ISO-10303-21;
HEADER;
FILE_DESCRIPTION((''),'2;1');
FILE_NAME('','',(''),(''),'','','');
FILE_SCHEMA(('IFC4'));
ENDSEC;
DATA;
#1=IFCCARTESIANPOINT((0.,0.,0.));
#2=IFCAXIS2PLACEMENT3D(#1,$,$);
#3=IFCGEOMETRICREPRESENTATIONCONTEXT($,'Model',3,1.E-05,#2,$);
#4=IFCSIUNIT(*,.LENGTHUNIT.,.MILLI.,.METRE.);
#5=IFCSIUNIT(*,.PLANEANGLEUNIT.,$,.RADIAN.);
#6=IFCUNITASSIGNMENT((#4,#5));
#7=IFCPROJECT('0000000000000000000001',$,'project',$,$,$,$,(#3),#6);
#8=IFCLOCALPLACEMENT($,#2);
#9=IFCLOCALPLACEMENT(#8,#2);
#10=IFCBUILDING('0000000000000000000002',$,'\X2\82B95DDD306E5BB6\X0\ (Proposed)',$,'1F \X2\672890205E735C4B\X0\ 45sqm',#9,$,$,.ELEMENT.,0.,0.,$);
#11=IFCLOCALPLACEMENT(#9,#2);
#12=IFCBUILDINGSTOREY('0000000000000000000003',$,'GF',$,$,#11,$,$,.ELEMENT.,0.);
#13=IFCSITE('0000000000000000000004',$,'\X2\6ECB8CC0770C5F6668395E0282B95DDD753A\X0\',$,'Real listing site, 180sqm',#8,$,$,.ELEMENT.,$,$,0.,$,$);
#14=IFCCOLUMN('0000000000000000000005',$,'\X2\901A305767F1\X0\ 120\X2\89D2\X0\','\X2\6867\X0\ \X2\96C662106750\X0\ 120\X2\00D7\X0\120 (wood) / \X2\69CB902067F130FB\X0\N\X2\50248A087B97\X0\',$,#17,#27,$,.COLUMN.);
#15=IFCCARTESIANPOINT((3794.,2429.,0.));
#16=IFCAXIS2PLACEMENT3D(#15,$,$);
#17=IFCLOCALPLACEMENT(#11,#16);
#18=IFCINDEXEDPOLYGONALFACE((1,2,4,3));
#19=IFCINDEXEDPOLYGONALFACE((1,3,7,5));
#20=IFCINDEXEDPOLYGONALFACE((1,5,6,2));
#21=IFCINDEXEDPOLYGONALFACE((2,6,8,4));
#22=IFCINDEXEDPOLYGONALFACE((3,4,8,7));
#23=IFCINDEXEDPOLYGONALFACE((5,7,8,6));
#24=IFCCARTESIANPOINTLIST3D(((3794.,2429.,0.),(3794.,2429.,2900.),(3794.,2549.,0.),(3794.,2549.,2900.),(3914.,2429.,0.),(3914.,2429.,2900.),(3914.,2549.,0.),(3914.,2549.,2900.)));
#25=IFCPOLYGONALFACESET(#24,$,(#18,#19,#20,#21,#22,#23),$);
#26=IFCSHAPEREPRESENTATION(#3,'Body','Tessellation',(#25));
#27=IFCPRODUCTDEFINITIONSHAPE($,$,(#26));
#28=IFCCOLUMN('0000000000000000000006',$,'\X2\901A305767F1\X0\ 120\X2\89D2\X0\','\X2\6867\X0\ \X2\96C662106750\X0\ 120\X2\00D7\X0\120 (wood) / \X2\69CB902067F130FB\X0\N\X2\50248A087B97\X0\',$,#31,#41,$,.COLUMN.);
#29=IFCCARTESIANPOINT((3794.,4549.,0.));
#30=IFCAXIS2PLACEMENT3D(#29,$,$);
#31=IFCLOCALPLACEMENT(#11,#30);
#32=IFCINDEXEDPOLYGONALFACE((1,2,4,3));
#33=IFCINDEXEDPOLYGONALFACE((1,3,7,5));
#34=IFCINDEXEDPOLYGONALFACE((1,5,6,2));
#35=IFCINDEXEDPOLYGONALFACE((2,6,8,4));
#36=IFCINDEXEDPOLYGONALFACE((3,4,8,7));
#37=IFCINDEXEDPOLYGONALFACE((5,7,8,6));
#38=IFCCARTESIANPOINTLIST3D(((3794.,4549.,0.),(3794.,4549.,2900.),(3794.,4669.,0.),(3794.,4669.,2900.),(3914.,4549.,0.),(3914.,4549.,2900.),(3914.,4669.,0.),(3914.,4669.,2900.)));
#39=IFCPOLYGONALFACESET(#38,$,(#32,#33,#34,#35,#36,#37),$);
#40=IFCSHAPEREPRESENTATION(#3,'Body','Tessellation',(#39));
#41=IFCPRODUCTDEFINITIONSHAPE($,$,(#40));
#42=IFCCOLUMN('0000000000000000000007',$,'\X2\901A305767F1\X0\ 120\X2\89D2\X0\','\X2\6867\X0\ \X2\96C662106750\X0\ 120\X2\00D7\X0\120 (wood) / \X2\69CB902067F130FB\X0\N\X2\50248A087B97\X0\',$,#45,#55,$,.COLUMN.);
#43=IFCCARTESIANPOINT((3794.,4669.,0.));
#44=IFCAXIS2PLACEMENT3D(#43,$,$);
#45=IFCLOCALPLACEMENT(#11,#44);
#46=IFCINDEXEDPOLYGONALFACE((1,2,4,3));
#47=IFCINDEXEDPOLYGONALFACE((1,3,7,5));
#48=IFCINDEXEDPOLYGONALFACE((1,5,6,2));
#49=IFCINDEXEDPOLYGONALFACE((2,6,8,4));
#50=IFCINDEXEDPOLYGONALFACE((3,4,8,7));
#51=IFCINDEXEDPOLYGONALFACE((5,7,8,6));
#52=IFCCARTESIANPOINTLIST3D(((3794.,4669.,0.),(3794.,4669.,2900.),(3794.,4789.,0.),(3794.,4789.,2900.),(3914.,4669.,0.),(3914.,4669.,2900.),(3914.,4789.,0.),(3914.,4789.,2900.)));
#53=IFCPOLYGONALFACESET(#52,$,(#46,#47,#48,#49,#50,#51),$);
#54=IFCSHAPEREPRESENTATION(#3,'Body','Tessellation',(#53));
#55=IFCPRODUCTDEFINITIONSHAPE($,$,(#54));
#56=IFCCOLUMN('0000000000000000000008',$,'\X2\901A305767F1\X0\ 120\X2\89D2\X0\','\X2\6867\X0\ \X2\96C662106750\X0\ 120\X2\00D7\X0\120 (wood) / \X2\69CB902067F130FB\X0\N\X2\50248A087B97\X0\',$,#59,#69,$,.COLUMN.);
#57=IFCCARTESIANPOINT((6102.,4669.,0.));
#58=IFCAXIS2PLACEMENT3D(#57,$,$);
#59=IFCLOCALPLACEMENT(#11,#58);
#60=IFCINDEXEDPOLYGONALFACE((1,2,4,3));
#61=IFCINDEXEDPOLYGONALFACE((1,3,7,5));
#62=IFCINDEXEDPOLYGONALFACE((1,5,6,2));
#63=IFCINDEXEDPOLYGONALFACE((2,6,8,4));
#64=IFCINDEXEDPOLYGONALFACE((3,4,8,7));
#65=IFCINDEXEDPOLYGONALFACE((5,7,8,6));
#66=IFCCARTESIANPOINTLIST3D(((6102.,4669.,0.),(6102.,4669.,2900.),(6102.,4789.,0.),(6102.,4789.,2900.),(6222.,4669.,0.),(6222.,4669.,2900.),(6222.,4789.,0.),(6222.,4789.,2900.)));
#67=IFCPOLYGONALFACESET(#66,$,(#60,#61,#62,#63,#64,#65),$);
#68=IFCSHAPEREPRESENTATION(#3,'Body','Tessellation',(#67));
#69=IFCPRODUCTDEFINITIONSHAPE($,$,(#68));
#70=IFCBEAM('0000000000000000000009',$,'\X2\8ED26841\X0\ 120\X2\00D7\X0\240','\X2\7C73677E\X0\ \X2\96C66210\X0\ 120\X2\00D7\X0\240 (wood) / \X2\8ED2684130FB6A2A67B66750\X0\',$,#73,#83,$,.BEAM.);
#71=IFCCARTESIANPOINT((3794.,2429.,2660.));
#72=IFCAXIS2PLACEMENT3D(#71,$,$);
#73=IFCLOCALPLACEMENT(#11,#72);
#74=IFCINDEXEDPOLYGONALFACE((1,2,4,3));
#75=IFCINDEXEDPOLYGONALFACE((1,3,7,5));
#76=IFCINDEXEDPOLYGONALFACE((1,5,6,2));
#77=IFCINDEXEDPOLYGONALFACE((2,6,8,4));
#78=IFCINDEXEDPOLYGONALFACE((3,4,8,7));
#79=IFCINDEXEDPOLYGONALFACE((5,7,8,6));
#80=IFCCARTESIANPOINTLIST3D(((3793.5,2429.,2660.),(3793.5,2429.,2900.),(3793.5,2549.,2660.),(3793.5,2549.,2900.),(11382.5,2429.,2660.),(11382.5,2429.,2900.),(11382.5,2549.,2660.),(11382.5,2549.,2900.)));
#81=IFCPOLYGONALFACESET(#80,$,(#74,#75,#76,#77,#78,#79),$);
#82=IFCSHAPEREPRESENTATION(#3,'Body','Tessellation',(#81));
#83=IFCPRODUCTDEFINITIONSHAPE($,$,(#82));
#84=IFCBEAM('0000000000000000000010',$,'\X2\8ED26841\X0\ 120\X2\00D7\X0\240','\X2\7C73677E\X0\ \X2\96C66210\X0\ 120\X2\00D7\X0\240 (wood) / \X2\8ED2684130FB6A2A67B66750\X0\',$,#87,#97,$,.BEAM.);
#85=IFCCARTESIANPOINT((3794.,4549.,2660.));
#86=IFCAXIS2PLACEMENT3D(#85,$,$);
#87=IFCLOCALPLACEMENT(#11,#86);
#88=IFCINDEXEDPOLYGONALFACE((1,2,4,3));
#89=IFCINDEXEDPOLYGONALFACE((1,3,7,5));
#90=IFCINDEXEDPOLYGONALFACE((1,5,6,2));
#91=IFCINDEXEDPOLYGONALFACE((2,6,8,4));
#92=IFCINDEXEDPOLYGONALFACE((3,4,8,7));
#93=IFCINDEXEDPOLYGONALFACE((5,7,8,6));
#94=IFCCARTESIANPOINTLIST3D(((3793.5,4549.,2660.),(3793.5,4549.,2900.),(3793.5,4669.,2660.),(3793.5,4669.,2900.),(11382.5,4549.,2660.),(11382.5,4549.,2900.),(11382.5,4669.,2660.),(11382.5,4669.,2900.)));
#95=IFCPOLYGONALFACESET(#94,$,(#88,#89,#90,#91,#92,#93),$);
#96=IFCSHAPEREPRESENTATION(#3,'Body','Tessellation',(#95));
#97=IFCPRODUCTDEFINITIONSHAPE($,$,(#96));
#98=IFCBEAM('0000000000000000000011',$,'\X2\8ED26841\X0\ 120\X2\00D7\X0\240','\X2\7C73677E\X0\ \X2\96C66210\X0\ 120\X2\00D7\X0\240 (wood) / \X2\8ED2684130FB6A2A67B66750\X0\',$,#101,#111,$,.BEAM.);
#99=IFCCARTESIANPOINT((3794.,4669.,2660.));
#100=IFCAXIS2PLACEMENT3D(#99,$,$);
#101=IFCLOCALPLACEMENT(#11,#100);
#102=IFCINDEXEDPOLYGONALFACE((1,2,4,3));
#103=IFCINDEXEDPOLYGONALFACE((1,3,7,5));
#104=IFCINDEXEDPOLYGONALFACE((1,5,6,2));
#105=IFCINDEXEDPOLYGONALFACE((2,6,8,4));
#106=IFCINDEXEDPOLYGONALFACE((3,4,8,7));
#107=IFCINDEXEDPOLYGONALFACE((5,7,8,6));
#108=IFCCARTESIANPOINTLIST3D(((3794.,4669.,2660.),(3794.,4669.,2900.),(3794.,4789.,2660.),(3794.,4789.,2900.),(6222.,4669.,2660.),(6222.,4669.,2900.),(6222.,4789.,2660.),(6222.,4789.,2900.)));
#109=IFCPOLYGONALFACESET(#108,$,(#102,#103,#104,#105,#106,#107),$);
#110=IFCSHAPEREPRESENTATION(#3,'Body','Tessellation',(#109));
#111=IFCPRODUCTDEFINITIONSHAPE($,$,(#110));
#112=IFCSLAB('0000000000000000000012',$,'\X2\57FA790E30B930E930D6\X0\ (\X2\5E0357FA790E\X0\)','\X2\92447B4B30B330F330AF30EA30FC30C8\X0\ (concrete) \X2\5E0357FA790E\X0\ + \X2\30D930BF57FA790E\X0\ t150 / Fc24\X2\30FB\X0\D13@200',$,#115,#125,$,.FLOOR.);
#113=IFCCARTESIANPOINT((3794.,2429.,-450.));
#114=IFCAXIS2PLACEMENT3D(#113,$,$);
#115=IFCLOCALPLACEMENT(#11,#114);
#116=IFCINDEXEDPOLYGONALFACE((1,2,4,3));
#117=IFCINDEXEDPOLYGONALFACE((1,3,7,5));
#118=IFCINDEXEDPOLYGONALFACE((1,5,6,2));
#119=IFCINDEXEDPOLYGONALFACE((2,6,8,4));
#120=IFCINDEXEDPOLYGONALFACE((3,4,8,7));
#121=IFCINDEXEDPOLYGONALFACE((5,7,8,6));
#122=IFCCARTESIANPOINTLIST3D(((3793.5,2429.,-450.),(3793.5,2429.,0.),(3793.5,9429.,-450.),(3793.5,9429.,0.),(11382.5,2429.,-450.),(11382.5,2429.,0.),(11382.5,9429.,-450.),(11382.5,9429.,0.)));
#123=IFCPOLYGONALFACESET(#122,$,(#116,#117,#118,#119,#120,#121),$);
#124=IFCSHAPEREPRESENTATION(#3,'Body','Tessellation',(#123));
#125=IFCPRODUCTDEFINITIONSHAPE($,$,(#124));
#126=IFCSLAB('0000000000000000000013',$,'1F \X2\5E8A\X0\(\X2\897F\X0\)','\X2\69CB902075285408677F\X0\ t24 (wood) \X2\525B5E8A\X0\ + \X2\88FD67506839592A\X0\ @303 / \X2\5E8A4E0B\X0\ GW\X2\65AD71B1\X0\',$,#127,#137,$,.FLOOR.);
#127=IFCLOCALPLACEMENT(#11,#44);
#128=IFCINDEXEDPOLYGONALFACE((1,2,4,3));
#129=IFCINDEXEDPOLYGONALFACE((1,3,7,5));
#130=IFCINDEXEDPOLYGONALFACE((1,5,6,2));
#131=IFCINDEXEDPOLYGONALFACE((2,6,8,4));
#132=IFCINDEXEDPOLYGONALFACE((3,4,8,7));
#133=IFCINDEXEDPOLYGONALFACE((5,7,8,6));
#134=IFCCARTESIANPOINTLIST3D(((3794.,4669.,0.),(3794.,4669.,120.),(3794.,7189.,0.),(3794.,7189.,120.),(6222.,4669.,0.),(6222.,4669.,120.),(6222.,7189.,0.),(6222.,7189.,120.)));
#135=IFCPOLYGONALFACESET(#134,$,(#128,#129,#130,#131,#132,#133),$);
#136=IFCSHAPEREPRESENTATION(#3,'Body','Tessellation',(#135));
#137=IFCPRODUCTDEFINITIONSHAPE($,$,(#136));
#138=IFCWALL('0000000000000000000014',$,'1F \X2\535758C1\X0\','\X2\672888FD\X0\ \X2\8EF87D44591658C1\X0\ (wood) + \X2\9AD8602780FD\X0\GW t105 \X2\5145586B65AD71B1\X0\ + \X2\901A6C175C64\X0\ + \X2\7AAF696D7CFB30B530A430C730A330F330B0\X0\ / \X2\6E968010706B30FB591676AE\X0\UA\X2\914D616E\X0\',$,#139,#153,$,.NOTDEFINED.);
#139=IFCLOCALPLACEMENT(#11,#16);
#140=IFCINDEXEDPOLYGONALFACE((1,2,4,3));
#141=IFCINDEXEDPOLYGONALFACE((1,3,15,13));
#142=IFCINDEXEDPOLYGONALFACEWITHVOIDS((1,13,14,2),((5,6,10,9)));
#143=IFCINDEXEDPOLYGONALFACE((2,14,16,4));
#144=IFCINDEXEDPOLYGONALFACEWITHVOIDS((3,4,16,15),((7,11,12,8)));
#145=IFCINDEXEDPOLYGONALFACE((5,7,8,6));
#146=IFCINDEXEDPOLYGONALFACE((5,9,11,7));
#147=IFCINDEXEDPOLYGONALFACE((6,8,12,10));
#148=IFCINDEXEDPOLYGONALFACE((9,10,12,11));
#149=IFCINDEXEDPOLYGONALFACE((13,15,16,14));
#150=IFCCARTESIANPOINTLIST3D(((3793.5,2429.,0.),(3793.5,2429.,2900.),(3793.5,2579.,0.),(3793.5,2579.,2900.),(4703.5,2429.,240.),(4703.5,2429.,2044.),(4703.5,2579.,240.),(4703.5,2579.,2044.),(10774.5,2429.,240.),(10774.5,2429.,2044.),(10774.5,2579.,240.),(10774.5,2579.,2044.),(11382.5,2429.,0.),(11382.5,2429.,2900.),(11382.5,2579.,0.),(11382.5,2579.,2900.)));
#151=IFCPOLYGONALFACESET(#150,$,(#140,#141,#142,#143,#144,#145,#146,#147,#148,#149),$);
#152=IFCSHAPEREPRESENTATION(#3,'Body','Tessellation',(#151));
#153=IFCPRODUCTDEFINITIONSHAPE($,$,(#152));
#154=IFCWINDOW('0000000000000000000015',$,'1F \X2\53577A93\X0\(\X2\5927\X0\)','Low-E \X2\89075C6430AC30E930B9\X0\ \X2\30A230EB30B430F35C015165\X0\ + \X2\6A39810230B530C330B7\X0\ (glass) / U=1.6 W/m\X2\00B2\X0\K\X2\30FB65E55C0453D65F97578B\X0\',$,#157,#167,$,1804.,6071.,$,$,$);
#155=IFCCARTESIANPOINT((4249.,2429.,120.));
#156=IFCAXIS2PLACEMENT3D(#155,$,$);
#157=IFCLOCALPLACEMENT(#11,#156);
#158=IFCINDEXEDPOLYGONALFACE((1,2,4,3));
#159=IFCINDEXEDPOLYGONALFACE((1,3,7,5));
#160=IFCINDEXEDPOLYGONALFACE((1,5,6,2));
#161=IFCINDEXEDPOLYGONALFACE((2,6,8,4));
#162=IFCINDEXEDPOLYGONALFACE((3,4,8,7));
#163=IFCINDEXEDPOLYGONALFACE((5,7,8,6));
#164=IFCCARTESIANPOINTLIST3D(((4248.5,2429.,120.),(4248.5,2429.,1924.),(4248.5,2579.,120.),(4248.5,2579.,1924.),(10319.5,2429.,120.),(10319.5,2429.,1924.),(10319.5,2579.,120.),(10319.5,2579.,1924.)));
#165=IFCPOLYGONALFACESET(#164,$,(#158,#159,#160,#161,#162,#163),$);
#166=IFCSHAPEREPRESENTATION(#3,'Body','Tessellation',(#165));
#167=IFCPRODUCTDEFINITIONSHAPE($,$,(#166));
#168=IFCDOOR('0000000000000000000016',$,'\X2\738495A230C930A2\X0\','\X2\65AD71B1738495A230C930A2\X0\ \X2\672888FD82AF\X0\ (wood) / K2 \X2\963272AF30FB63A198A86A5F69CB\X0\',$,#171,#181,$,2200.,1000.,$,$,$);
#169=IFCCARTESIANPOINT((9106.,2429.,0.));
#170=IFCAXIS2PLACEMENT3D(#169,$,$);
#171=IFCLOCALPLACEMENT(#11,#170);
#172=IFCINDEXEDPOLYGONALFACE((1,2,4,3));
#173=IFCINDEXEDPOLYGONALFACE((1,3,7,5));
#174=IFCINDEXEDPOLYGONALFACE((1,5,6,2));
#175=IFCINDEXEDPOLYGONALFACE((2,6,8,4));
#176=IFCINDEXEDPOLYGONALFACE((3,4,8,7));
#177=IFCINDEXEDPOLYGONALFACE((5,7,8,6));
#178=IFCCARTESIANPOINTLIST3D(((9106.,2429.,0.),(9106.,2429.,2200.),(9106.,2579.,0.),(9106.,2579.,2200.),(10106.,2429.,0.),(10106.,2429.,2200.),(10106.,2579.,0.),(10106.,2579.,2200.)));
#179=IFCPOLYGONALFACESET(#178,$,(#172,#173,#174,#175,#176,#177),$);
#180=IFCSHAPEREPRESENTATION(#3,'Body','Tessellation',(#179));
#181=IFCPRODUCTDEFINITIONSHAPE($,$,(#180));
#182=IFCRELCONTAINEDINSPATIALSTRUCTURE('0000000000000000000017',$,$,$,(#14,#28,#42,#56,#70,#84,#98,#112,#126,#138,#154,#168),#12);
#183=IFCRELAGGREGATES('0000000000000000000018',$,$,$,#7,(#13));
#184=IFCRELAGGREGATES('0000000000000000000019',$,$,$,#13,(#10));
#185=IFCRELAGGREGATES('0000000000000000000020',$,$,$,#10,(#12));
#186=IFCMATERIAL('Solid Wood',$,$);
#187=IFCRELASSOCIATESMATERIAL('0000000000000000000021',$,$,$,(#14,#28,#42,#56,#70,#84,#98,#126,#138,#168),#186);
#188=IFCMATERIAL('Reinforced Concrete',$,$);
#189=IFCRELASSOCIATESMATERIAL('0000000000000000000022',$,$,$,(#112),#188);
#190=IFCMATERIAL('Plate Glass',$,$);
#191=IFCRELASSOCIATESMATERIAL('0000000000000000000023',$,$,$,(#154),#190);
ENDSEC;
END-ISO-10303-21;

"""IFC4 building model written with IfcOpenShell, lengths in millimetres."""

from ifc_helpers import new_model, si_unit, frame, frame_2d, origin, place, context, project, spatial, rectangle, extrude, material, element, fill, save


model = new_model("IFC4")

# Units and contexts
model_context = context("Model", 3, precision=1e-05, world=origin())
ifc_project = project(units=[si_unit("LENGTHUNIT", "METRE", prefix="MILLI"), si_unit("PLANEANGLEUNIT", "RADIAN")], contexts=[model_context])

# Site, building, storey
site_placement = place(None, origin())
site = spatial("IfcSite", under=ifc_project, at=site_placement, Name="滋賀県彦根市芹川町", ObjectType="Real listing site, 180sqm", CompositionType="ELEMENT", RefElevation=0.0)
building_placement = place(site_placement, origin())
building = spatial("IfcBuilding", under=site, at=building_placement, Name="芹川の家 (Proposed)", ObjectType="1F 木造平屋 45sqm", CompositionType="ELEMENT", ElevationOfRefHeight=0.0, ElevationOfTerrain=0.0)
storey_placement = place(building_placement, origin())
storey = spatial("IfcBuildingStorey", under=building, at=storey_placement, Name="GF", CompositionType="ELEMENT", Elevation=0.0)

# Columns
ifc_material_1 = material(Name="Solid Wood")
column_1_placement = place(storey_placement, frame((3794.0, 2429.0, 0.0)))
element("IfcColumn", 1, at=column_1_placement, inside=storey, material=ifc_material_1, Name="通し柱 120角", Description="桧 集成材 120×120 (wood) / 構造柱・N値計算", PredefinedType="COLUMN", context=model_context, shape_type="SweptSolid", body=[
    extrude(rectangle(XDim=120.0, YDim=120.0, at=frame_2d((60.0, 60.0))), frame((3794.0, 2429.0, 0.0)), (0.0, 0.0, 1.0), 2900.0),
])
column_2_placement = place(storey_placement, frame((3794.0, 4549.0, 0.0)))
element("IfcColumn", 2, at=column_2_placement, inside=storey, material=ifc_material_1, Name="通し柱 120角", Description="桧 集成材 120×120 (wood) / 構造柱・N値計算", PredefinedType="COLUMN", context=model_context, shape_type="SweptSolid", body=[
    extrude(rectangle(XDim=120.0, YDim=120.0, at=frame_2d((60.0, 60.0))), frame((3794.0, 4549.0, 0.0)), (0.0, 0.0, 1.0), 2900.0),
])
column_3_placement = place(storey_placement, frame((3794.0, 4669.0, 0.0)))
element("IfcColumn", 3, at=column_3_placement, inside=storey, material=ifc_material_1, Name="通し柱 120角", Description="桧 集成材 120×120 (wood) / 構造柱・N値計算", PredefinedType="COLUMN", context=model_context, shape_type="SweptSolid", body=[
    extrude(rectangle(XDim=120.0, YDim=120.0, at=frame_2d((60.0, 60.0))), frame((3794.0, 4669.0, 0.0)), (0.0, 0.0, 1.0), 2900.0),
])
column_4_placement = place(storey_placement, frame((6102.0, 4669.0, 0.0)))
element("IfcColumn", 4, at=column_4_placement, inside=storey, material=ifc_material_1, Name="通し柱 120角", Description="桧 集成材 120×120 (wood) / 構造柱・N値計算", PredefinedType="COLUMN", context=model_context, shape_type="SweptSolid", body=[
    extrude(rectangle(XDim=120.0, YDim=120.0, at=frame_2d((60.0, 60.0))), frame((6102.0, 4669.0, 0.0)), (0.0, 0.0, 1.0), 2900.0),
])

# Beams
beam_1_placement = place(storey_placement, frame((3794.0, 2429.0, 2660.0)))
element("IfcBeam", 5, at=beam_1_placement, inside=storey, material=ifc_material_1, Name="軒桁 120×240", Description="米松 集成 120×240 (wood) / 軒桁・横架材", PredefinedType="BEAM", context=model_context, shape_type="SweptSolid", body=[
    extrude(rectangle(XDim=7589.0, YDim=120.0, at=frame_2d((3794.0, 60.0))), frame((3794.0, 2429.0, 2660.0)), (0.0, 0.0, 1.0), 240.0),
])
beam_2_placement = place(storey_placement, frame((3794.0, 4549.0, 2660.0)))
element("IfcBeam", 6, at=beam_2_placement, inside=storey, material=ifc_material_1, Name="軒桁 120×240", Description="米松 集成 120×240 (wood) / 軒桁・横架材", PredefinedType="BEAM", context=model_context, shape_type="SweptSolid", body=[
    extrude(rectangle(XDim=7589.0, YDim=120.0, at=frame_2d((3794.0, 60.0))), frame((3794.0, 4549.0, 2660.0)), (0.0, 0.0, 1.0), 240.0),
])
beam_3_placement = place(storey_placement, frame((3794.0, 4669.0, 2660.0)))
element("IfcBeam", 7, at=beam_3_placement, inside=storey, material=ifc_material_1, Name="軒桁 120×240", Description="米松 集成 120×240 (wood) / 軒桁・横架材", PredefinedType="BEAM", context=model_context, shape_type="SweptSolid", body=[
    extrude(rectangle(XDim=2428.0, YDim=120.0, at=frame_2d((1214.0, 60.0))), frame((3794.0, 4669.0, 2660.0)), (0.0, 0.0, 1.0), 240.0),
])

# Slabs
ifc_material_2 = material(Name="Reinforced Concrete")
slab_1_placement = place(storey_placement, frame((3794.0, 2429.0, -450.0)))
element("IfcSlab", 8, at=slab_1_placement, inside=storey, material=ifc_material_2, Name="基礎スラブ (布基礎)", Description="鉄筋コンクリート (concrete) 布基礎 + ベタ基礎 t150 / Fc24・D13@200", PredefinedType="FLOOR", context=model_context, shape_type="SweptSolid", body=[
    extrude(rectangle(XDim=7589.0, YDim=7000.0, at=frame_2d((3794.0, 3500.0))), frame((3794.0, 2429.0, -450.0)), (0.0, 0.0, 1.0), 450.0),
])
slab_2_placement = place(storey_placement, frame((3794.0, 4669.0, 0.0)))
element("IfcSlab", 9, at=slab_2_placement, inside=storey, material=ifc_material_1, Name="1F 床(西)", Description="構造用合板 t24 (wood) 剛床 + 製材根太 @303 / 床下 GW断熱", PredefinedType="FLOOR", context=model_context, shape_type="SweptSolid", body=[
    extrude(rectangle(XDim=2428.0, YDim=2520.0, at=frame_2d((1214.0, 1260.0))), frame((3794.0, 4669.0, 0.0)), (0.0, 0.0, 1.0), 120.0),
])

# Wall, openings, window, door
wall_1_placement = place(storey_placement, frame((3794.0, 2429.0, 0.0)))
wall_1 = element("IfcWall", 10, at=wall_1_placement, inside=storey, material=ifc_material_1, Name="1F 南壁", Description="木製 軸組外壁 (wood) + 高性能GW t105 充填断熱 + 通気層 + 窯業系サイディング / 準耐火・外皮UA配慮", PredefinedType="NOTDEFINED", context=model_context, shape_type="SweptSolid", body=[
    extrude(rectangle(XDim=7589.0, YDim=150.0, at=frame_2d((3794.0, 75.0))), frame((3794.0, 2429.0, 0.0)), (0.0, 0.0, 1.0), 2900.0),
])
opening_1_placement = place(storey_placement, frame((4249.0, 2429.0, 120.0)))
opening_1 = element("IfcOpeningElement", 11, at=opening_1_placement, cuts=wall_1, PredefinedType="NOTDEFINED", context=model_context, shape_type="SweptSolid", body=[
    extrude(rectangle(XDim=6071.0, YDim=150.0, at=frame_2d((3035.0, 75.0))), frame((4249.0, 2429.0, 120.0)), (0.0, 0.0, 1.0), 1804.0),
])
opening_2_placement = place(storey_placement, frame((9106.0, 2429.0, 0.0)))
opening_2 = element("IfcOpeningElement", 12, at=opening_2_placement, cuts=wall_1, PredefinedType="NOTDEFINED", context=model_context, shape_type="SweptSolid", body=[
    extrude(rectangle(XDim=1000.0, YDim=150.0, at=frame_2d((500.0, 75.0))), frame((9106.0, 2429.0, 0.0)), (0.0, 0.0, 1.0), 2200.0),
])
ifc_material_3 = material(Name="Plate Glass")
window_1_placement = place(storey_placement, frame((4249.0, 2429.0, 120.0)))
window_1 = element("IfcWindow", 13, at=window_1_placement, inside=storey, material=ifc_material_3, Name="1F 南窓(大)", Description="Low-E 複層ガラス アルゴン封入 + 樹脂サッシ (glass) / U=1.6 W/m²K・日射取得型", OverallHeight=1804.0, OverallWidth=6071.0, context=model_context, shape_type="SweptSolid", body=[
    extrude(rectangle(XDim=6071.0, YDim=150.0, at=frame_2d((3035.0, 75.0))), frame((4249.0, 2429.0, 120.0)), (0.0, 0.0, 1.0), 1804.0),
])
fill(opening_1, window_1)
door_placement = place(storey_placement, frame((9106.0, 2429.0, 0.0)))
door = element("IfcDoor", 14, at=door_placement, inside=storey, material=ifc_material_1, Name="玄関ドア", Description="断熱玄関ドア 木製芯 (wood) / K2 防犯・採風機構", OverallHeight=2200.0, OverallWidth=1000.0, context=model_context, shape_type="SweptSolid", body=[
    extrude(rectangle(XDim=1000.0, YDim=150.0, at=frame_2d((500.0, 75.0))), frame((9106.0, 2429.0, 0.0)), (0.0, 0.0, 1.0), 2200.0),
])
fill(opening_2, door)

save(model, "model.ifc")
